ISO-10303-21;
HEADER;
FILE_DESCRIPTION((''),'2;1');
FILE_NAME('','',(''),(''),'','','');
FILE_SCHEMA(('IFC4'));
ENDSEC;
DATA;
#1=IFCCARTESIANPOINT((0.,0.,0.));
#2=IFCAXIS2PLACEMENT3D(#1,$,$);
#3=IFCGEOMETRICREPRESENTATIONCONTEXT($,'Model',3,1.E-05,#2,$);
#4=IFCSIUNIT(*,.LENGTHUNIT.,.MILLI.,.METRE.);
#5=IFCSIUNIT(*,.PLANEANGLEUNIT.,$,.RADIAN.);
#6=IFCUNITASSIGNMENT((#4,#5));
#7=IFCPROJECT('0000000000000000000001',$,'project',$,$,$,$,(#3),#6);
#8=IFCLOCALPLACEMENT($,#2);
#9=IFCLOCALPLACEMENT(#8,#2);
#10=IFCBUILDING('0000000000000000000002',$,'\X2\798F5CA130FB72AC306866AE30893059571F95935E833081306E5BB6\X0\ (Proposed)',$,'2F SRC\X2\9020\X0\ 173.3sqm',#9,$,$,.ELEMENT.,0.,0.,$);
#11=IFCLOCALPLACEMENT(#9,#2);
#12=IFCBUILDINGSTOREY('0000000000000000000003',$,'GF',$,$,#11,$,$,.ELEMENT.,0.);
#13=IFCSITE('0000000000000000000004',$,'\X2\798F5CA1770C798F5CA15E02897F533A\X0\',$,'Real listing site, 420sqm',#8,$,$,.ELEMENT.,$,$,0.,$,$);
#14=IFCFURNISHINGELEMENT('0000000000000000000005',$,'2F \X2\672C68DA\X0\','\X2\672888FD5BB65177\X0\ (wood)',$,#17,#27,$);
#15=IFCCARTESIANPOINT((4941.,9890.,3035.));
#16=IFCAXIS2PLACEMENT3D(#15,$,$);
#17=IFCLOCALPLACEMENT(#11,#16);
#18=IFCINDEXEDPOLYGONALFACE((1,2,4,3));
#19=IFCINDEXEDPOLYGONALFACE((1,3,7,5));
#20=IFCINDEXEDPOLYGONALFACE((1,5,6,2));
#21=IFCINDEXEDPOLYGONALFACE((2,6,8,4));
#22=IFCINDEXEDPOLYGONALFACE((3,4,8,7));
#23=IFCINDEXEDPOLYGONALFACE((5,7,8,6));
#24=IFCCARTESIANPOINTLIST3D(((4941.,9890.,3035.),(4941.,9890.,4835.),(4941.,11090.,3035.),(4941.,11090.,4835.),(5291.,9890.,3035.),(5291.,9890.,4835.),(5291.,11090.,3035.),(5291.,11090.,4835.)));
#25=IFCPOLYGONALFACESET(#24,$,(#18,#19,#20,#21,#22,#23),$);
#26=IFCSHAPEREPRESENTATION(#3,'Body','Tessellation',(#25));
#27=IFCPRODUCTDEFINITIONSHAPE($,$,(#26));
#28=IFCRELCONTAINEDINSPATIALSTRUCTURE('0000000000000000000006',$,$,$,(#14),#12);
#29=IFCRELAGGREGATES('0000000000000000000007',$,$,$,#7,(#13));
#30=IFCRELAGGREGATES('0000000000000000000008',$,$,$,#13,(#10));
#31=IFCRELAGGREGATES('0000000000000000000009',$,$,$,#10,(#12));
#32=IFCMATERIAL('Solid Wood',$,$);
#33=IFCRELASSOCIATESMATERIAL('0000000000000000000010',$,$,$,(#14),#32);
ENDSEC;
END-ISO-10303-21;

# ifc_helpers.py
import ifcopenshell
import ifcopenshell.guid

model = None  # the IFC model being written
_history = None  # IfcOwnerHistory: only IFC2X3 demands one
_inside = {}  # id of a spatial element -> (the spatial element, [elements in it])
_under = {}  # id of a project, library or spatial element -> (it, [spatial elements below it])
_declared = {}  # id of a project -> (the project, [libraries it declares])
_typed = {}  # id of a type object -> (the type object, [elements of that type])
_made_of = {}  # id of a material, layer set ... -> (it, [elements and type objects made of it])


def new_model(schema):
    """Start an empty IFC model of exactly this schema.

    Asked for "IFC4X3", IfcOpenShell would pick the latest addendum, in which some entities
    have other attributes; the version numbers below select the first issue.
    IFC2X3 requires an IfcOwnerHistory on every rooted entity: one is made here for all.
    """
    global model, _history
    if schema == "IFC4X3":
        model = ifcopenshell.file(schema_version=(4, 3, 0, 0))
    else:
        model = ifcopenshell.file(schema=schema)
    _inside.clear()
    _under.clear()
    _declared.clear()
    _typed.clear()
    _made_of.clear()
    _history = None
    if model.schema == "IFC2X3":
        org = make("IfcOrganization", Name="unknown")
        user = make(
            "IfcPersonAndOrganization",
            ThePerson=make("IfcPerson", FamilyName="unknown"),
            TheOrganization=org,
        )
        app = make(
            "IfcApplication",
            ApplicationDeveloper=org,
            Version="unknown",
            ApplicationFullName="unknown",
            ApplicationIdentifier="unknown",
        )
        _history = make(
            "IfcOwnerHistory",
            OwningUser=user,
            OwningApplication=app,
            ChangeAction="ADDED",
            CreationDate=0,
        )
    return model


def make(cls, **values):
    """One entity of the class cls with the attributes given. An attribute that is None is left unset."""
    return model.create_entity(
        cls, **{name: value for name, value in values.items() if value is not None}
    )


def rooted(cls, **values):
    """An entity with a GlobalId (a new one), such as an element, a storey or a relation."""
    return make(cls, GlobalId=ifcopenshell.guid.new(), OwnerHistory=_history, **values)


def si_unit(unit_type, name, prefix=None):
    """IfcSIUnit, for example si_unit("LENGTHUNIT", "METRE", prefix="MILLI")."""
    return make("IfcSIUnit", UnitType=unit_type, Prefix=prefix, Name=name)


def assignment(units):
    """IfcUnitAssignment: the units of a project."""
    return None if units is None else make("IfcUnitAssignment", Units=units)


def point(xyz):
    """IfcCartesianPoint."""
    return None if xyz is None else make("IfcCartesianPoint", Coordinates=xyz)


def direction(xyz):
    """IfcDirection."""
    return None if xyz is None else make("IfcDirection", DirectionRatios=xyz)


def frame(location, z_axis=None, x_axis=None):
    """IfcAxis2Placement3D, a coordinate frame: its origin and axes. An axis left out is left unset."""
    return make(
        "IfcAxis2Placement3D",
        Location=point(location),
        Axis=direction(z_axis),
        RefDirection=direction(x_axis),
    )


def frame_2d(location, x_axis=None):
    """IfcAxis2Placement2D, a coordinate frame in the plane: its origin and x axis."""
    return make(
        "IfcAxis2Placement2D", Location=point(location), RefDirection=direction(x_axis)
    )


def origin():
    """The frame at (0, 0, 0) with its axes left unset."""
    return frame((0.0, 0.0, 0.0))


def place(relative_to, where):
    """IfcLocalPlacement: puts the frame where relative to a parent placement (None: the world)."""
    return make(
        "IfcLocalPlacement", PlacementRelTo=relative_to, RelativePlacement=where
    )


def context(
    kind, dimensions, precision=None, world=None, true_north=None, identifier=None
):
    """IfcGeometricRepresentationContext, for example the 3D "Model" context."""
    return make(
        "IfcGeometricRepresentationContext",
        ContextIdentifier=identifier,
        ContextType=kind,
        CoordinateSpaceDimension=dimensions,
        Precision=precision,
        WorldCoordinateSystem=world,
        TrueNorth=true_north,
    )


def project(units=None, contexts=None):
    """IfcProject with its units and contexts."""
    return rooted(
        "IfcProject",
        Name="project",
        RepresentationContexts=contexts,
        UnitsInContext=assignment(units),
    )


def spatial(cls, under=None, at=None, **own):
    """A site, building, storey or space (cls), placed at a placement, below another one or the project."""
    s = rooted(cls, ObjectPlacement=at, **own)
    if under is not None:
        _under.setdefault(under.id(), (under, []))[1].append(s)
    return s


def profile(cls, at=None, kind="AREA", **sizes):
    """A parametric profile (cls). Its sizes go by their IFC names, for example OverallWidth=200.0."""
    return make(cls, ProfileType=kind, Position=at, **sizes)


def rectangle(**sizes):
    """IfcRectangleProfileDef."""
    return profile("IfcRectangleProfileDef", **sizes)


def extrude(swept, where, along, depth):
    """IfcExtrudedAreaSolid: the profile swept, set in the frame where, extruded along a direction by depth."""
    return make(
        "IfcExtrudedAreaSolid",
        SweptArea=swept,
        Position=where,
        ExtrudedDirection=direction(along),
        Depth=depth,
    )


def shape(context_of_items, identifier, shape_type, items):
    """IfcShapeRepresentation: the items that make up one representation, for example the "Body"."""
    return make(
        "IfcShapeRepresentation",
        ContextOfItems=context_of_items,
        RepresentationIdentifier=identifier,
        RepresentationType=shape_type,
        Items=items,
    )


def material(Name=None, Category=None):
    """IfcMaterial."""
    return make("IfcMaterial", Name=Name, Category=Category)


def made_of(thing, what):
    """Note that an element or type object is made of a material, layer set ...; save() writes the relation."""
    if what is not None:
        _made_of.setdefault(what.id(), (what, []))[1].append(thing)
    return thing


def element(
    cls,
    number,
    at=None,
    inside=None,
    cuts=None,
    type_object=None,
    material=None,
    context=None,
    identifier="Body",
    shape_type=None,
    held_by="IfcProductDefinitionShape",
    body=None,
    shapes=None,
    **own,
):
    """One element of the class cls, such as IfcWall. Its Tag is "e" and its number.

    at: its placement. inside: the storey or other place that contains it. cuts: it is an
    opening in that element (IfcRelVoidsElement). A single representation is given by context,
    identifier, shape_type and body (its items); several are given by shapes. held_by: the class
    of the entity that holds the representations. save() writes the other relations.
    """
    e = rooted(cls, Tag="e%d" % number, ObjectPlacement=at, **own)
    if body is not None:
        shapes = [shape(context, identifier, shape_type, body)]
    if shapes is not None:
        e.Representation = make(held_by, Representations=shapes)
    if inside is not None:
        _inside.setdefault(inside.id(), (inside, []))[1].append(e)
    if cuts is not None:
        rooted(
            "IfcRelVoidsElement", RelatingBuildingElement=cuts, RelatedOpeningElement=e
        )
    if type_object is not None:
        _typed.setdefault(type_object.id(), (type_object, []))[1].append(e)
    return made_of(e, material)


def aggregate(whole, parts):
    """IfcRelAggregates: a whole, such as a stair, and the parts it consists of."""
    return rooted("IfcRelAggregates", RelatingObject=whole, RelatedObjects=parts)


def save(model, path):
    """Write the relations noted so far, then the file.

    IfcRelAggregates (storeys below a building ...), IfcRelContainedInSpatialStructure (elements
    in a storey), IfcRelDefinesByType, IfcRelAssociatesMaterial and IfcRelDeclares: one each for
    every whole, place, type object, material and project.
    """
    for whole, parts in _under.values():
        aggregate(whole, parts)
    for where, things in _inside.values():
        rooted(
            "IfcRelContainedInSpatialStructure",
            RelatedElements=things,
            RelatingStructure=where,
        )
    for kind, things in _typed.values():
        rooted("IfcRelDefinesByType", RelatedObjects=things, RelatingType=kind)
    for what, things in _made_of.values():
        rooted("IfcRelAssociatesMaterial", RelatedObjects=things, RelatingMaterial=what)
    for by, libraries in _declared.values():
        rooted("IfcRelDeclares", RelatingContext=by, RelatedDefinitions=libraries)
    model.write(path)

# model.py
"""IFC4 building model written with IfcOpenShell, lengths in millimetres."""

from ifc_helpers import new_model, si_unit, frame, frame_2d, origin, place, context, project, spatial, rectangle, extrude, material, element, save


model = new_model("IFC4")

# Units and contexts
model_context = context("Model", 3, precision=1e-05, world=origin())
ifc_project = project(units=[si_unit("LENGTHUNIT", "METRE", prefix="MILLI"), si_unit("PLANEANGLEUNIT", "RADIAN")], contexts=[model_context])

# Site, building, storey
site_placement = place(None, origin())
site = spatial("IfcSite", under=ifc_project, at=site_placement, Name="福岡県福岡市西区", ObjectType="Real listing site, 420sqm", CompositionType="ELEMENT", RefElevation=0.0)
building_placement = place(site_placement, origin())
building = spatial("IfcBuilding", under=site, at=building_placement, Name="福岡・犬と暮らす土間広めの家 (Proposed)", ObjectType="2F SRC造 173.3sqm", CompositionType="ELEMENT", ElevationOfRefHeight=0.0, ElevationOfTerrain=0.0)
storey_placement = place(building_placement, origin())
storey = spatial("IfcBuildingStorey", under=building, at=storey_placement, Name="GF", CompositionType="ELEMENT", Elevation=0.0)

# Shared definitions
ifc_material_1 = material(Name="Solid Wood")

# Furnishing element
furnishing_1_placement = place(storey_placement, frame((4941.0, 9890.0, 3035.0)))
element("IfcFurnishingElement", 1, at=furnishing_1_placement, inside=storey, material=ifc_material_1, Name="2F 本棚", Description="木製家具 (wood)", context=model_context, shape_type="SweptSolid", body=[
    extrude(rectangle(XDim=350.0, YDim=1200.0, at=frame_2d((175.0, 600.0))), frame((4941.0, 9890.0, 3035.0)), (0.0, 0.0, 1.0), 1800.0),
])

save(model, "model.ifc")
